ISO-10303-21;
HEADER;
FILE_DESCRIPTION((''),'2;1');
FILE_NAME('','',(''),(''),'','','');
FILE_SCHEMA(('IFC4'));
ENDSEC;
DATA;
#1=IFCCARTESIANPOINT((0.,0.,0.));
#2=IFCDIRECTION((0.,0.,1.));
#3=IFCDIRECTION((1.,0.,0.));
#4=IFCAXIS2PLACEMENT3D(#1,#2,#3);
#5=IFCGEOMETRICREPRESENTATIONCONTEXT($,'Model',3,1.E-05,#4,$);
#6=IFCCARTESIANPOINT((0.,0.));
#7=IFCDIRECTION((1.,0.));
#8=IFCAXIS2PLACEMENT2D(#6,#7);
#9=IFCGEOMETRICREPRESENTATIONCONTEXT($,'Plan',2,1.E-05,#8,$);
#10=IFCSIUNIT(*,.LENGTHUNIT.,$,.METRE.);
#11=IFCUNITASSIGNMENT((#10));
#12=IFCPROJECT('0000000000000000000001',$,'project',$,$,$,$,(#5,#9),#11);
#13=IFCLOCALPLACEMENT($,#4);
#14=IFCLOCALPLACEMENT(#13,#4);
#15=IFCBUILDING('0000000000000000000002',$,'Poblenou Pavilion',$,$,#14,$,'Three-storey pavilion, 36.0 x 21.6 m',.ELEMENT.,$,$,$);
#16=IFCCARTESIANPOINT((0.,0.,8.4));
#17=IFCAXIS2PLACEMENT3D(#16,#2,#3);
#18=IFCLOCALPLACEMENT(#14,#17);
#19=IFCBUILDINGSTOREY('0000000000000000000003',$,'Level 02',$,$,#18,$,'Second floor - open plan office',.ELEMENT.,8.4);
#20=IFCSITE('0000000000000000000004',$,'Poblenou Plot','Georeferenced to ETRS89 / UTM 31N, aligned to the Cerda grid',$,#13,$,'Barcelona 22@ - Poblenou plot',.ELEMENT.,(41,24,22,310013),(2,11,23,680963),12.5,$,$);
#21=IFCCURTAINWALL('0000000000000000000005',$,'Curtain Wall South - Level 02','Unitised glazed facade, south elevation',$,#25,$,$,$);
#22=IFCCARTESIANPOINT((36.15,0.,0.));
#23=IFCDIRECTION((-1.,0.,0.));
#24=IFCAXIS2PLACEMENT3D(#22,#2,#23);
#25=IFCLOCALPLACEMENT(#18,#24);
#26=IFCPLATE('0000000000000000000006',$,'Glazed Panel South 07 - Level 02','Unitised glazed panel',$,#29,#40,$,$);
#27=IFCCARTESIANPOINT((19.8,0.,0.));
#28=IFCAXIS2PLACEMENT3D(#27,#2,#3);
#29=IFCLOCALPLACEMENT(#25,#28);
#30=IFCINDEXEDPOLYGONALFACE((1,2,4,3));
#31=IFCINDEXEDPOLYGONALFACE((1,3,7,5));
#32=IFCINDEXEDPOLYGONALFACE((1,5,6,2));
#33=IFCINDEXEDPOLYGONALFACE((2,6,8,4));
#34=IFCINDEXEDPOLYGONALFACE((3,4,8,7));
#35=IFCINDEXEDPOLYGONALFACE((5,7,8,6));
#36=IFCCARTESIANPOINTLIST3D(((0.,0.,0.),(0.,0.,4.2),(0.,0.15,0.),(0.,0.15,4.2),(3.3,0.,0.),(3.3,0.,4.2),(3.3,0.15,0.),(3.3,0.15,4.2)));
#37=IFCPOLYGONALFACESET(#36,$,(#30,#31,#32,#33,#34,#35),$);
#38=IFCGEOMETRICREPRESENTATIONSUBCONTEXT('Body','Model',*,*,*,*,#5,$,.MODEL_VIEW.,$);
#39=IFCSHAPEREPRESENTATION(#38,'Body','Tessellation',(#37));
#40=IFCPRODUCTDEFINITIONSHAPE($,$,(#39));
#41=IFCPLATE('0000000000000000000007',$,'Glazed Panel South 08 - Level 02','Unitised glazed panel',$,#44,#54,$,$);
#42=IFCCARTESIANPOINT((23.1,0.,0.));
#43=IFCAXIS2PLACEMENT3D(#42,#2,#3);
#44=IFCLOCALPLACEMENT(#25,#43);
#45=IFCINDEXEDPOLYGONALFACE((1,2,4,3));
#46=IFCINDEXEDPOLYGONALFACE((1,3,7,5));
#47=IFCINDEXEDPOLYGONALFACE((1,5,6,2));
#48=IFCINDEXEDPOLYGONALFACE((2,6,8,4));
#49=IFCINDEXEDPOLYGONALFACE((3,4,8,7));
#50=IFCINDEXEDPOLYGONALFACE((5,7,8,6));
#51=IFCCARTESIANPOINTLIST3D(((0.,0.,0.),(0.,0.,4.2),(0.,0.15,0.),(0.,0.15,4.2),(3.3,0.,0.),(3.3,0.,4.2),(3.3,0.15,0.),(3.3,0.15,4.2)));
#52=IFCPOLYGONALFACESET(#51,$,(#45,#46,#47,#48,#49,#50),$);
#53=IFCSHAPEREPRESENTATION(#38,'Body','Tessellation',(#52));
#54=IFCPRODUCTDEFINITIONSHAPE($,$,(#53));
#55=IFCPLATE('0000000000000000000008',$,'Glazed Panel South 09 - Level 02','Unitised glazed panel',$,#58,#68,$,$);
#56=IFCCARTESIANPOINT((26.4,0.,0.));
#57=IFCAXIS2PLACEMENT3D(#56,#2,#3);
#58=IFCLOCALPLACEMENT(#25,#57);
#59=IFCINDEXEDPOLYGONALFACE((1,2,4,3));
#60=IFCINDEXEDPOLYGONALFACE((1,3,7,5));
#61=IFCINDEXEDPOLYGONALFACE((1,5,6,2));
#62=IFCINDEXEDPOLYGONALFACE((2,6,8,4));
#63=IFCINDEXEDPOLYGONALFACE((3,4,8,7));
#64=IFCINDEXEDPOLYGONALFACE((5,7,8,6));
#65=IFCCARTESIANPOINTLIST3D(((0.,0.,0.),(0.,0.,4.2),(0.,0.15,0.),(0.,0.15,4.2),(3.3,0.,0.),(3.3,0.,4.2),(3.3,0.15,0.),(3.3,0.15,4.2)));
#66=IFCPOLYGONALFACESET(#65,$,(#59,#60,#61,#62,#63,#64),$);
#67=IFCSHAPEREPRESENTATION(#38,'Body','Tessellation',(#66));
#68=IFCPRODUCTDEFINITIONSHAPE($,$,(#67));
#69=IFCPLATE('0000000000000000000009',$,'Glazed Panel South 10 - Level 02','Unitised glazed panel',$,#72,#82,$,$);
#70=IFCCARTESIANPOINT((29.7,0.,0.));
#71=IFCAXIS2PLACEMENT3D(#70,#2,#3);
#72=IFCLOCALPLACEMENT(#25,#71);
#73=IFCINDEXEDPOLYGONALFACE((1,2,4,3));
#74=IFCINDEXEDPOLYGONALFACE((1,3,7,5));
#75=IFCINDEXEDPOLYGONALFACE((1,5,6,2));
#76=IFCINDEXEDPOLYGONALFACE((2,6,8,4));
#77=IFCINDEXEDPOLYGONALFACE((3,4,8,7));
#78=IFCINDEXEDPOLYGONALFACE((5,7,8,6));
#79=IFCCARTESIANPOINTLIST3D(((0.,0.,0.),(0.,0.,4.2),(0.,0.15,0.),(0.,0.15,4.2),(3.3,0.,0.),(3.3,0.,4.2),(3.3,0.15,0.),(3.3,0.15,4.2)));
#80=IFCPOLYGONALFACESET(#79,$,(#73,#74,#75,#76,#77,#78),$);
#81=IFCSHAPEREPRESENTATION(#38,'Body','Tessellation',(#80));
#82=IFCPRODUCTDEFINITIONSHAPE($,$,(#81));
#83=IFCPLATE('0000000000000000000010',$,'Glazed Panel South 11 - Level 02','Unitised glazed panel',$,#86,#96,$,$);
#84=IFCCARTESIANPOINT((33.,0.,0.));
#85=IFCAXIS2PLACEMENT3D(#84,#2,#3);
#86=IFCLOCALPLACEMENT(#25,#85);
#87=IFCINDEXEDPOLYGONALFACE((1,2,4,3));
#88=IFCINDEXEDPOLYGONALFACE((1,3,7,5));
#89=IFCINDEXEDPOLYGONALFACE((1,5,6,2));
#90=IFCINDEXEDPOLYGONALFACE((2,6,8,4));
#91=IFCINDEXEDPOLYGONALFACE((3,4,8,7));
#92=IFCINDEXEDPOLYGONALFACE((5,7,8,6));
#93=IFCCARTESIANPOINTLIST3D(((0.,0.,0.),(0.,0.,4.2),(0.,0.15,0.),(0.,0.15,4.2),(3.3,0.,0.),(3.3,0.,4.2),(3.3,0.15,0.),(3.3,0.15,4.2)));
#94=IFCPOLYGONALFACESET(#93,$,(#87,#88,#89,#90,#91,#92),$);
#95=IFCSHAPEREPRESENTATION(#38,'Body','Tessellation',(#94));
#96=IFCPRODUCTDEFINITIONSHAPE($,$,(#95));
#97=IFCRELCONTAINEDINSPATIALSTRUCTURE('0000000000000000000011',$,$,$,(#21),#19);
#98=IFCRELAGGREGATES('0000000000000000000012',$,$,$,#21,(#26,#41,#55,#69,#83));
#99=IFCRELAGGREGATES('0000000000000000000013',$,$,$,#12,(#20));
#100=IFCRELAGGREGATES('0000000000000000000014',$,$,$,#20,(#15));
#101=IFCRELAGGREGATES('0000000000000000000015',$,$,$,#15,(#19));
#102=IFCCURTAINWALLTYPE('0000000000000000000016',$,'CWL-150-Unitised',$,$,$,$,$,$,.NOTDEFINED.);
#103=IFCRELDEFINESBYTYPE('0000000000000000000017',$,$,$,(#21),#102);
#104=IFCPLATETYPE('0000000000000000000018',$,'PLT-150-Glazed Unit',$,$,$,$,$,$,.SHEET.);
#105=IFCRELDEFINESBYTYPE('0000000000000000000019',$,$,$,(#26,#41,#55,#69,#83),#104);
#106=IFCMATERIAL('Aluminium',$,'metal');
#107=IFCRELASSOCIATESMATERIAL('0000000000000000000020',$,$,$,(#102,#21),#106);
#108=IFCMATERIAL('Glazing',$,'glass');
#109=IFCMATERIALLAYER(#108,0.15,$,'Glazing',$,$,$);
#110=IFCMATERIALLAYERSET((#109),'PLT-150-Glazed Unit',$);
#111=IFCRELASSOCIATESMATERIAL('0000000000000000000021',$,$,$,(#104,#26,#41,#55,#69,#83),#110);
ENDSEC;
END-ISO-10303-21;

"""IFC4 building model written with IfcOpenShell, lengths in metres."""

from ifc_helpers import new_model, si_unit, frame, origin_with_axes, origin_2d_with_axis, place, context, subcontext, project, spatial, line, indexed_curve, outline, extrude, material, layer, layer_set, layer_usage, type_object, element, aggregate, save


model = new_model("IFC4")

# Units and contexts
model_context = context("Model", 3, precision=1e-05, world=origin_with_axes())
plan_context = context("Plan", 2, precision=1e-05, world=origin_2d_with_axis())
body_context = subcontext(model_context, "Body", "Model", "MODEL_VIEW")
ifc_project = project(units=[si_unit("LENGTHUNIT", "METRE")], contexts=[model_context, plan_context])

# Site, building, storey
site_placement = place(None, origin_with_axes())
site = spatial("IfcSite", under=ifc_project, at=site_placement, Name="Poblenou Plot", Description="Georeferenced to ETRS89 / UTM 31N, aligned to the Cerda grid", LongName="Barcelona 22@ - Poblenou plot", CompositionType="ELEMENT", RefLatitude=(41, 24, 22, 310013), RefLongitude=(2, 11, 23, 680963), RefElevation=12.5)
building_placement = place(site_placement, origin_with_axes())
building = spatial("IfcBuilding", under=site, at=building_placement, Name="Poblenou Pavilion", LongName="Three-storey pavilion, 36.0 x 21.6 m", CompositionType="ELEMENT")
storey_placement = place(building_placement, frame((0.0, 0.0, 8.4), z_axis=(0.0, 0.0, 1.0), x_axis=(1.0, 0.0, 0.0)))
storey = spatial("IfcBuildingStorey", under=building, at=storey_placement, Name="Level 02", LongName="Second floor - open plan office", CompositionType="ELEMENT", Elevation=8.4)

# Curtain wall, plates
ifc_material_1 = material(Name="Aluminium", Category="metal")
curtain_wall_type = type_object("IfcCurtainWallType", Name="CWL-150-Unitised", PredefinedType="NOTDEFINED", material=ifc_material_1)
curtain_wall_1_placement = place(storey_placement, frame((36.15, 0.0, 0.0), z_axis=(0.0, 0.0, 1.0), x_axis=(-1.0, 0.0, 0.0)))
curtain_wall_1 = element("IfcCurtainWall", 1, at=curtain_wall_1_placement, inside=storey, type_object=curtain_wall_type, material=ifc_material_1, Name="Curtain Wall South - Level 02", Description="Unitised glazed facade, south elevation")
ifc_material_2 = material(Name="Glazing", Category="glass")
ifc_layer_1 = layer(ifc_material_2, 0.15, Name="Glazing")
ifc_layer_set_1 = layer_set([ifc_layer_1], Name="PLT-150-Glazed Unit")
ifc_layer_usage_1 = layer_usage(ifc_layer_set_1, "AXIS2", "POSITIVE", 0.0)
plate_type = type_object("IfcPlateType", Name="PLT-150-Glazed Unit", PredefinedType="SHEET", material=ifc_layer_set_1)
plate_1_placement = place(curtain_wall_1_placement, frame((19.8, 0.0, 0.0), z_axis=(0.0, 0.0, 1.0), x_axis=(1.0, 0.0, 0.0)))
plate_1 = element("IfcPlate", 2, at=plate_1_placement, type_object=plate_type, material=ifc_layer_usage_1, Name="Glazed Panel South 07 - Level 02", Description="Unitised glazed panel", context=body_context, shape_type="SweptSolid", body=[
    extrude(outline(indexed_curve([(0.0, 0.0), (3.3, 0.0), (3.3, 0.15), (0.0, 0.15)], segments=[line(1, 2, 3, 4, 1)])), origin_with_axes(), (0.0, 0.0, 1.0), 4.2),
])
ifc_layer_usage_2 = layer_usage(ifc_layer_set_1, "AXIS2", "POSITIVE", 0.0)
plate_2_placement = place(curtain_wall_1_placement, frame((23.1, 0.0, 0.0), z_axis=(0.0, 0.0, 1.0), x_axis=(1.0, 0.0, 0.0)))
plate_2 = element("IfcPlate", 3, at=plate_2_placement, type_object=plate_type, material=ifc_layer_usage_2, Name="Glazed Panel South 08 - Level 02", Description="Unitised glazed panel", context=body_context, shape_type="SweptSolid", body=[
    extrude(outline(indexed_curve([(0.0, 0.0), (3.3, 0.0), (3.3, 0.15), (0.0, 0.15)], segments=[line(1, 2, 3, 4, 1)])), origin_with_axes(), (0.0, 0.0, 1.0), 4.2),
])
ifc_layer_usage_3 = layer_usage(ifc_layer_set_1, "AXIS2", "POSITIVE", 0.0)
plate_3_placement = place(curtain_wall_1_placement, frame((26.4, 0.0, 0.0), z_axis=(0.0, 0.0, 1.0), x_axis=(1.0, 0.0, 0.0)))
plate_3 = element("IfcPlate", 4, at=plate_3_placement, type_object=plate_type, material=ifc_layer_usage_3, Name="Glazed Panel South 09 - Level 02", Description="Unitised glazed panel", context=body_context, shape_type="SweptSolid", body=[
    extrude(outline(indexed_curve([(0.0, 0.0), (3.3, 0.0), (3.3, 0.15), (0.0, 0.15)], segments=[line(1, 2, 3, 4, 1)])), origin_with_axes(), (0.0, 0.0, 1.0), 4.2),
])
ifc_layer_usage_4 = layer_usage(ifc_layer_set_1, "AXIS2", "POSITIVE", 0.0)
plate_4_placement = place(curtain_wall_1_placement, frame((29.7, 0.0, 0.0), z_axis=(0.0, 0.0, 1.0), x_axis=(1.0, 0.0, 0.0)))
plate_4 = element("IfcPlate", 5, at=plate_4_placement, type_object=plate_type, material=ifc_layer_usage_4, Name="Glazed Panel South 10 - Level 02", Description="Unitised glazed panel", context=body_context, shape_type="SweptSolid", body=[
    extrude(outline(indexed_curve([(0.0, 0.0), (3.3, 0.0), (3.3, 0.15), (0.0, 0.15)], segments=[line(1, 2, 3, 4, 1)])), origin_with_axes(), (0.0, 0.0, 1.0), 4.2),
])
ifc_layer_usage_5 = layer_usage(ifc_layer_set_1, "AXIS2", "POSITIVE", 0.0)
plate_5_placement = place(curtain_wall_1_placement, frame((33.0, 0.0, 0.0), z_axis=(0.0, 0.0, 1.0), x_axis=(1.0, 0.0, 0.0)))
plate_5 = element("IfcPlate", 6, at=plate_5_placement, type_object=plate_type, material=ifc_layer_usage_5, Name="Glazed Panel South 11 - Level 02", Description="Unitised glazed panel", context=body_context, shape_type="SweptSolid", body=[
    extrude(outline(indexed_curve([(0.0, 0.0), (3.3, 0.0), (3.3, 0.15), (0.0, 0.15)], segments=[line(1, 2, 3, 4, 1)])), origin_with_axes(), (0.0, 0.0, 1.0), 4.2),
])
aggregate(curtain_wall_1, [plate_1, plate_2, plate_3, plate_4, plate_5])

save(model, "model.ifc")
